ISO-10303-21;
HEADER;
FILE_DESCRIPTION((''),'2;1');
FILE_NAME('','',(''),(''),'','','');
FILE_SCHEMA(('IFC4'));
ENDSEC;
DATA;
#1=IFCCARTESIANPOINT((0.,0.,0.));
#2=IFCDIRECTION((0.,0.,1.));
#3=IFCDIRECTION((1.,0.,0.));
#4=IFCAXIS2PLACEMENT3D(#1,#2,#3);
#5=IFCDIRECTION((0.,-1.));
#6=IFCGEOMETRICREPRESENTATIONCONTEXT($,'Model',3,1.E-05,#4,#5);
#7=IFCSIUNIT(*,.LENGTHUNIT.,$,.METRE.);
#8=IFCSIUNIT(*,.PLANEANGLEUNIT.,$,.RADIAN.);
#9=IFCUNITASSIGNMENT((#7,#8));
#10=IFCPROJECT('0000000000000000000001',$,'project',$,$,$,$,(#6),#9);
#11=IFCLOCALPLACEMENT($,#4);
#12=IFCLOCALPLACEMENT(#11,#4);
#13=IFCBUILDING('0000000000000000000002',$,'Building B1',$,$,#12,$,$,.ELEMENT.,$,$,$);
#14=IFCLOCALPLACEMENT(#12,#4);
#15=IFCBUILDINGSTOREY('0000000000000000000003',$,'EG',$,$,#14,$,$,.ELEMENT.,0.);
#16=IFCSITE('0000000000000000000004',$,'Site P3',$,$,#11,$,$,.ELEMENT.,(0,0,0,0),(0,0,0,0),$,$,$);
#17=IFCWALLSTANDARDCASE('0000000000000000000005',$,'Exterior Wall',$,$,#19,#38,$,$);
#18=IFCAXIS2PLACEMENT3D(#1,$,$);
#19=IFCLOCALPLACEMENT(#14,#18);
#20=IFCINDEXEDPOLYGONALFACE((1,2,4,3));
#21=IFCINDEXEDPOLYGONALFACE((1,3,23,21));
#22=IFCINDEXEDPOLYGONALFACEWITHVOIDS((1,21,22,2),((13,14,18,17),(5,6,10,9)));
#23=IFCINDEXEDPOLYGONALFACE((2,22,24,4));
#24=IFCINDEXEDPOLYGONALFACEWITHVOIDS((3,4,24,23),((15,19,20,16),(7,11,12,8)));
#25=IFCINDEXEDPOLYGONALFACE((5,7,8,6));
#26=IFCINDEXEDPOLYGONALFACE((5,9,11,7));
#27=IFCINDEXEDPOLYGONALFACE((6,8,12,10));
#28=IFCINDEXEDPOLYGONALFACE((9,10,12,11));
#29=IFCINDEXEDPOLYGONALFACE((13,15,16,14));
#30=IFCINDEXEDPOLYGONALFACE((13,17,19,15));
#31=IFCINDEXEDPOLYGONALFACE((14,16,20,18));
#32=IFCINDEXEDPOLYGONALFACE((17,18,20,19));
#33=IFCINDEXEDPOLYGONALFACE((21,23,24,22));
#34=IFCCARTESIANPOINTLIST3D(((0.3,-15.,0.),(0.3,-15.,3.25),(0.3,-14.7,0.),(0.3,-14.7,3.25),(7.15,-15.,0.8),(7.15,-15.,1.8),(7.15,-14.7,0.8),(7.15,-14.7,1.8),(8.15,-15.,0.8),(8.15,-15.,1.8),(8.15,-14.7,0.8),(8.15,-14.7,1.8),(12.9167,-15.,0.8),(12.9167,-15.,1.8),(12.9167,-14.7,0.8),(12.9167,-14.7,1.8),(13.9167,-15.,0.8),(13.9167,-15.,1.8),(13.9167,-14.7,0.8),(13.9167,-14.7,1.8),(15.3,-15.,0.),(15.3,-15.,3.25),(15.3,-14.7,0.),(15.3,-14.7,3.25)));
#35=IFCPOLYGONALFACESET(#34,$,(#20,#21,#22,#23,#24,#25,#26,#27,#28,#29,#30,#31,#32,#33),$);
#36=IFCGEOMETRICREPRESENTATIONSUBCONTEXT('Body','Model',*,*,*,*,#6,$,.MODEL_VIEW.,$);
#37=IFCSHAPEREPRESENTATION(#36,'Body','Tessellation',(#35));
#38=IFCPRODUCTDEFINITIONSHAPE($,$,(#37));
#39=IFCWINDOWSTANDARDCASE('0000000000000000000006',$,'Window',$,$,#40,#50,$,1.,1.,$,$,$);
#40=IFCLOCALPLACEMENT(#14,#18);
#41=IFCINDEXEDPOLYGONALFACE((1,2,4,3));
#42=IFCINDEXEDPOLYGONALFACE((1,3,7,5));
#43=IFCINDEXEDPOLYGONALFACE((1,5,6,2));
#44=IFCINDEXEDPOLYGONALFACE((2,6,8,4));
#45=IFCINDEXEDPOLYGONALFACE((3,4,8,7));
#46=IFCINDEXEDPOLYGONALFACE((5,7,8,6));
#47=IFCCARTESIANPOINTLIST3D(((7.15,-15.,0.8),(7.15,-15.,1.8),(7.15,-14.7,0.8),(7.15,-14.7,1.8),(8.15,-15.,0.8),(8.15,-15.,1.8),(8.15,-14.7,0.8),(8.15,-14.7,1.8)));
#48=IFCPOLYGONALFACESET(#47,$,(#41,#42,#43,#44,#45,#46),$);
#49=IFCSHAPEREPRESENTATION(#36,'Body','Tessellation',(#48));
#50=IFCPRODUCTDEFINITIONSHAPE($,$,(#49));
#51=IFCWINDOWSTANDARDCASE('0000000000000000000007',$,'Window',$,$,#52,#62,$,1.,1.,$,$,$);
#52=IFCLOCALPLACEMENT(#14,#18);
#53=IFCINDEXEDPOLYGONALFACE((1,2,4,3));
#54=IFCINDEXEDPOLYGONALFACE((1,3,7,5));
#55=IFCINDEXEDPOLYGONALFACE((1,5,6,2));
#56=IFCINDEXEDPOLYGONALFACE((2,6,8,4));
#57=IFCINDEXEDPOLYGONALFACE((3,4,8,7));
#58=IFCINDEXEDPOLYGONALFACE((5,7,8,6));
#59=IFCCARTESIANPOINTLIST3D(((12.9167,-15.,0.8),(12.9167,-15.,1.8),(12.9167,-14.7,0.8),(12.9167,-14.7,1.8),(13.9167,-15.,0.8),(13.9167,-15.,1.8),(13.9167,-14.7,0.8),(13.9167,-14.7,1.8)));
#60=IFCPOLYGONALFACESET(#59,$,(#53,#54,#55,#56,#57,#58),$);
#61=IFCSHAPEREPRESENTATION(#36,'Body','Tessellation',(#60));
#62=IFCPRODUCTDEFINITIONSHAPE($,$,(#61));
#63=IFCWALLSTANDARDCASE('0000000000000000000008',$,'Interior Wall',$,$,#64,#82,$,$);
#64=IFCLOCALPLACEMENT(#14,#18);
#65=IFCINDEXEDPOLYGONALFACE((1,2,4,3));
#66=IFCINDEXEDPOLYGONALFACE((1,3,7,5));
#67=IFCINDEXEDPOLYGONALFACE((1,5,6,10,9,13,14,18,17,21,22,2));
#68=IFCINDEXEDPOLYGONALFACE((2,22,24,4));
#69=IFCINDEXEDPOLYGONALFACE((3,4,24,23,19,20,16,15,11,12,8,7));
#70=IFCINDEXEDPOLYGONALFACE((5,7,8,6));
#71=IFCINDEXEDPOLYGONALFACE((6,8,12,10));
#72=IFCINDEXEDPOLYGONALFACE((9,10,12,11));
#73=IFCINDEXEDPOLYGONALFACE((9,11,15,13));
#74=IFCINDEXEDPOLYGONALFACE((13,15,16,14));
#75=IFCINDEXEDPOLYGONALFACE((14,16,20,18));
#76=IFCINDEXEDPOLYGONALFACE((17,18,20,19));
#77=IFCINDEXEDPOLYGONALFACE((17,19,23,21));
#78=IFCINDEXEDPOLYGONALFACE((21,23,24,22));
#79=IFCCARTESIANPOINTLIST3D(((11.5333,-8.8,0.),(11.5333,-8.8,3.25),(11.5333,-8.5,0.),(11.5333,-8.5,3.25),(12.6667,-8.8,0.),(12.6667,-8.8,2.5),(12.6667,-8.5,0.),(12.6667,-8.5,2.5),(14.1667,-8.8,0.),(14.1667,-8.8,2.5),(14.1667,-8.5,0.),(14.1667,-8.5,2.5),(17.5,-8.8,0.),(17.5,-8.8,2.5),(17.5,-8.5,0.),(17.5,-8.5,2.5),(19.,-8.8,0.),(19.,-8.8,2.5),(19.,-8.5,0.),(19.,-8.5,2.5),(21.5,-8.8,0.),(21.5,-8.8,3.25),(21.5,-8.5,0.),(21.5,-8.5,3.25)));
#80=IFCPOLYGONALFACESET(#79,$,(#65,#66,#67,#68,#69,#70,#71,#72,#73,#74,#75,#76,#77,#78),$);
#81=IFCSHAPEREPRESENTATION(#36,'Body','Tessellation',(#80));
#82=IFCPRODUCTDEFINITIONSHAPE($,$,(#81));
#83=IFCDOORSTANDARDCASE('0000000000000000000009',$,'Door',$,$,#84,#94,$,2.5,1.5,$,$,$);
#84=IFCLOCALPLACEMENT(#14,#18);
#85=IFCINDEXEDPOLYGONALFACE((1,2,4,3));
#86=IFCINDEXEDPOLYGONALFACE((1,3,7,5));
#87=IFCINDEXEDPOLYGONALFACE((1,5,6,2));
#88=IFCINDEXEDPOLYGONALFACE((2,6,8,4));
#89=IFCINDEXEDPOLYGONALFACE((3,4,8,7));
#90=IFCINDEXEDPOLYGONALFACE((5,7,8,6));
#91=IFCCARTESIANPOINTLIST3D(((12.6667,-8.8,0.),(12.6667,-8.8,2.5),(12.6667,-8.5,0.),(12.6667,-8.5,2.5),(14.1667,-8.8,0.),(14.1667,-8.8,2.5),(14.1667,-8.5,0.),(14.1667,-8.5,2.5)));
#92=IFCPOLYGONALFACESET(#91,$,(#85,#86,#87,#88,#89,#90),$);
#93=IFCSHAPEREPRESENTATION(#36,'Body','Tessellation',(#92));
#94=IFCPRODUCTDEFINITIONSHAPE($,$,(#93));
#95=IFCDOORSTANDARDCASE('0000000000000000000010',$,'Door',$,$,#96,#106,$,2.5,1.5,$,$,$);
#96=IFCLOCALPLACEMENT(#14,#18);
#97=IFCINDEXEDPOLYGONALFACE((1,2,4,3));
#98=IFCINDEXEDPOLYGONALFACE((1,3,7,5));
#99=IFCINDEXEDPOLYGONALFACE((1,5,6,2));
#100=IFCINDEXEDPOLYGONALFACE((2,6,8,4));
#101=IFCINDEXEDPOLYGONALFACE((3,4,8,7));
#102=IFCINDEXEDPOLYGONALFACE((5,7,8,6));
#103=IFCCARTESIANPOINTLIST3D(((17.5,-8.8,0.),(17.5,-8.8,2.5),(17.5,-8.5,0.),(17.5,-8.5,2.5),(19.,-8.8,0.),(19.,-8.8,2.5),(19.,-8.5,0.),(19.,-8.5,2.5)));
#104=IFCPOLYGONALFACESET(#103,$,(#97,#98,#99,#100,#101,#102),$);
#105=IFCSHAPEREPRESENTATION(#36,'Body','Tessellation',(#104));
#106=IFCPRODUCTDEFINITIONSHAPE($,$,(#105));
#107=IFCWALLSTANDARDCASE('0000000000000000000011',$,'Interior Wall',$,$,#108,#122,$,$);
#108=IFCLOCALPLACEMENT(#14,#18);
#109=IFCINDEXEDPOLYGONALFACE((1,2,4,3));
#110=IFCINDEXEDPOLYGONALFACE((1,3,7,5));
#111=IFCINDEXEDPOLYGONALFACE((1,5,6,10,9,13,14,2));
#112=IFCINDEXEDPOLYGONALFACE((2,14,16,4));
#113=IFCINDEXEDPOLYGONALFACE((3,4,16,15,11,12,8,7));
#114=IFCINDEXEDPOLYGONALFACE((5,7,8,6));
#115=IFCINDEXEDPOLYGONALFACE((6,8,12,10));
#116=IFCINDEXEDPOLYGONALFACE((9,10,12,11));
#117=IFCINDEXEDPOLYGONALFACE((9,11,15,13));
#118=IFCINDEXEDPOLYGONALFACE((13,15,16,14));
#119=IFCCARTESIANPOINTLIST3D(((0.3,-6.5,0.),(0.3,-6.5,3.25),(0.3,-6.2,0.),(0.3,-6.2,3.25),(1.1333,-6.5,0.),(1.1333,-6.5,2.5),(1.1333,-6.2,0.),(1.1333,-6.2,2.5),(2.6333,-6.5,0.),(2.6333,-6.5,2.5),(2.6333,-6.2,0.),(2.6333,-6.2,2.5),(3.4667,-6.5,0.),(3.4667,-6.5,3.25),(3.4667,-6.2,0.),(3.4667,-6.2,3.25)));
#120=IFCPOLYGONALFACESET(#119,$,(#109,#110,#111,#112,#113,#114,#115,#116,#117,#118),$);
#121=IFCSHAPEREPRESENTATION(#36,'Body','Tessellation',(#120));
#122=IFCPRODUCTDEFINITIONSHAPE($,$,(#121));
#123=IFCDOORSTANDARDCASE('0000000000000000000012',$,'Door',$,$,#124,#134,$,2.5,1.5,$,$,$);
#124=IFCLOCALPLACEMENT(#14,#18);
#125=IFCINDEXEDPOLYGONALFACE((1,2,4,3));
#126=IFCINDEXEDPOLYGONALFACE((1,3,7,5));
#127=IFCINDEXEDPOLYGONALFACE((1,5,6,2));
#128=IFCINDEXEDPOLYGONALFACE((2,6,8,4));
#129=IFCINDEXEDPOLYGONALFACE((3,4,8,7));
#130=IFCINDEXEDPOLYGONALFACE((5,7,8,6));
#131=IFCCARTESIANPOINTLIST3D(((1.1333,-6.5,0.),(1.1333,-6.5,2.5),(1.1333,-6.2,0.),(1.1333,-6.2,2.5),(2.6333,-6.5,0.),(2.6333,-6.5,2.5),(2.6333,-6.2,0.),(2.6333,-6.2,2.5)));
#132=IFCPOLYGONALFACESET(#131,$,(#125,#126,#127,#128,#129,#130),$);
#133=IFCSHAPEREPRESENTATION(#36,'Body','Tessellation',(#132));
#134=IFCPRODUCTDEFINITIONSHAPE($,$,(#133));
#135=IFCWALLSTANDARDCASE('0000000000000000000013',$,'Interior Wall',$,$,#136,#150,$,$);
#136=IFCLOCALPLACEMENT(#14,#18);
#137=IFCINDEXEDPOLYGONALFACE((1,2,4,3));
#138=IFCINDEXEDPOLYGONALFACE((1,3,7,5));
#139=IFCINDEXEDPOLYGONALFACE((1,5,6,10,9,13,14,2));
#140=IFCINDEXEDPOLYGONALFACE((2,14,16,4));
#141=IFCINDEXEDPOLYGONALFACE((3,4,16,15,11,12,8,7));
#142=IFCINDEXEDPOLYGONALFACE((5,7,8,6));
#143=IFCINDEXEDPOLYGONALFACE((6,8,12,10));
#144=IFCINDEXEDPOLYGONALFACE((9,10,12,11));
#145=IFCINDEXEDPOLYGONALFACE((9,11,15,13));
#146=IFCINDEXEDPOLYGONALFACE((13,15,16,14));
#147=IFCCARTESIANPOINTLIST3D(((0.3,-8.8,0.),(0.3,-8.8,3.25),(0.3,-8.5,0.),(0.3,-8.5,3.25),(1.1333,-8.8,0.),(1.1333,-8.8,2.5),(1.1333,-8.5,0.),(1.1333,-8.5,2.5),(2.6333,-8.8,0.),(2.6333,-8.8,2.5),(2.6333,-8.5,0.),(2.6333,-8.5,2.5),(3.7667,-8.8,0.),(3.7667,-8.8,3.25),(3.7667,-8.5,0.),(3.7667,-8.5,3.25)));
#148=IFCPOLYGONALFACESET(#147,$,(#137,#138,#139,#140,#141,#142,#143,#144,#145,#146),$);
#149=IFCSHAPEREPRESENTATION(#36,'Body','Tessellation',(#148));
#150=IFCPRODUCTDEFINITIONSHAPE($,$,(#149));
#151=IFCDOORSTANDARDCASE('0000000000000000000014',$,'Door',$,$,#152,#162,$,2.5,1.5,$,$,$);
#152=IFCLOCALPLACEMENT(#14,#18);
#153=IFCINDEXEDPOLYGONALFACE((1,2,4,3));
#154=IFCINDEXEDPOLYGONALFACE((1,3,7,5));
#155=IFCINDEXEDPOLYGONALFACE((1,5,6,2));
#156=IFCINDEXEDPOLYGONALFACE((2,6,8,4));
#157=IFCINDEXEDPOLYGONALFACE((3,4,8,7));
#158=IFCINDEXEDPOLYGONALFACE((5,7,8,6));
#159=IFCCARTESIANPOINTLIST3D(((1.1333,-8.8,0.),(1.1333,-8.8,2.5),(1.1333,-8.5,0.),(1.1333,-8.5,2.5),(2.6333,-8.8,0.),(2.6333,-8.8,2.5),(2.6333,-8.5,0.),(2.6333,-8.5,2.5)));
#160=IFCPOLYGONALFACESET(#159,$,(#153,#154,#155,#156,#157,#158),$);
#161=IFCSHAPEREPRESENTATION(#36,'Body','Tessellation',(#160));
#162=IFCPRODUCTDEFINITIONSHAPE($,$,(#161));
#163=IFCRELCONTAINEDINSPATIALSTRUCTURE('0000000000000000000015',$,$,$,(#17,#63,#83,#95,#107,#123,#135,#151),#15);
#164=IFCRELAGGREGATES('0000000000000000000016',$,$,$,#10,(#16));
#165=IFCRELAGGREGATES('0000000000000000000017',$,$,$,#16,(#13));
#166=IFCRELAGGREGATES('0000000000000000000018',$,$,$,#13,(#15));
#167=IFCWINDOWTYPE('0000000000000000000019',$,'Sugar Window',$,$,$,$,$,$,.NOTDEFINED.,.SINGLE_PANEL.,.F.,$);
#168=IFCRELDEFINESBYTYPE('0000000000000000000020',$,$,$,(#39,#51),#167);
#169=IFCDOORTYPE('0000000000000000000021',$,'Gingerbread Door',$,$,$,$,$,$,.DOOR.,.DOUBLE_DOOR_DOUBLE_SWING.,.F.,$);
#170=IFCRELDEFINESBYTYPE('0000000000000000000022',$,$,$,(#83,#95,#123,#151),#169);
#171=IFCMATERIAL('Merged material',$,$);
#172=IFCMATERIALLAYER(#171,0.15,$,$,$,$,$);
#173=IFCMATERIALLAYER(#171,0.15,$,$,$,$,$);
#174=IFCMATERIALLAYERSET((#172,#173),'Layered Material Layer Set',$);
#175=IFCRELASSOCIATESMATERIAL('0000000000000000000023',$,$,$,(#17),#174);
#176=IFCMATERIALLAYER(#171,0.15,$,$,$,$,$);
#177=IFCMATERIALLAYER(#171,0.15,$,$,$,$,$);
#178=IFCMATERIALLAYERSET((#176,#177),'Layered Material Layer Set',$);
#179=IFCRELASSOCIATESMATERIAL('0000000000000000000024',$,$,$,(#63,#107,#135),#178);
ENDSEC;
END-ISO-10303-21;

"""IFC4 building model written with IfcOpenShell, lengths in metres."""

from ifc_helpers import new_model, si_unit, direction, frame, origin_with_axes, place, context, subcontext, project, spatial, polyline, outline, extrude, source, transform, mapped, material, layer, layer_set, layer_usage, type_object, element, fill, save


model = new_model("IFC4")

# Units and contexts
model_context = context("Model", 3, precision=1e-05, world=origin_with_axes(), true_north=direction((0.0, -1.0)))
body_context = subcontext(model_context, "Body", "Model", "MODEL_VIEW")
ifc_project = project(units=[si_unit("LENGTHUNIT", "METRE"), si_unit("PLANEANGLEUNIT", "RADIAN")], contexts=[model_context])

# Site, building, storey
site_placement = place(None, origin_with_axes())
site = spatial("IfcSite", under=ifc_project, at=site_placement, Name="Site P3", CompositionType="ELEMENT", RefLatitude=(0, 0, 0, 0), RefLongitude=(0, 0, 0, 0))
building_placement = place(site_placement, origin_with_axes())
building = spatial("IfcBuilding", under=site, at=building_placement, Name="Building B1", CompositionType="ELEMENT")
storey_placement = place(building_placement, origin_with_axes())
storey = spatial("IfcBuildingStorey", under=building, at=storey_placement, Name="EG", CompositionType="ELEMENT", Elevation=0.0)

# Wall, openings, windows
ifc_material = material(Name="Merged material")
ifc_layer_1 = layer(ifc_material, 0.15)
ifc_layer_2 = layer(ifc_material, 0.15)
ifc_layer_set_1 = layer_set([ifc_layer_1, ifc_layer_2], Name="Layered Material Layer Set")
ifc_layer_usage_1 = layer_usage(ifc_layer_set_1, "AXIS2", "POSITIVE", -0.15)
wall_1_placement = place(storey_placement, frame((0.3, -14.85, 0.0), z_axis=(0.0, 0.0, 1.0), x_axis=(1.0, 0.0, 0.0)))
wall_1 = element("IfcWallStandardCase", 1, at=wall_1_placement, inside=storey, material=ifc_layer_usage_1, Name="Exterior Wall", context=body_context, shape_type="SweptSolid", body=[
    extrude(outline(polyline([(0.0, 0.15), (15.0, 0.15), (15.0, -0.15), (0.0, -0.15), (0.0, 0.15)])), origin_with_axes(), (0.0, 0.0, 1.0), 3.25),
])
opening_1_placement = place(wall_1_placement, frame((6.85, 0.0, 0.8), z_axis=(0.0, 0.0, 1.0), x_axis=(1.0, 0.0, 0.0)))
opening_1 = element("IfcOpeningStandardCase", 2, at=opening_1_placement, cuts=wall_1, context=body_context, shape_type="SweptSolid", body=[
    extrude(outline(polyline([(0.0, 0.0), (0.0, 1.0), (1.0, 1.0), (1.0, 0.0), (0.0, 0.0)])), frame((0.0, -0.15, 0.0), z_axis=(0.0, 1.0, 0.0), x_axis=(0.0, 0.0, 1.0)), (0.0, 0.0, 1.0), 0.3),
])
opening_2_placement = place(wall_1_placement, frame((12.6167, 0.0, 0.8), z_axis=(0.0, 0.0, 1.0), x_axis=(1.0, 0.0, 0.0)))
opening_2 = element("IfcOpeningStandardCase", 3, at=opening_2_placement, cuts=wall_1, context=body_context, shape_type="SweptSolid", body=[
    extrude(outline(polyline([(0.0, 0.0), (0.0, 1.0), (1.0, 1.0), (1.0, 0.0), (0.0, 0.0)])), frame((0.0, -0.15, 0.0), z_axis=(0.0, 1.0, 0.0), x_axis=(0.0, 0.0, 1.0)), (0.0, 0.0, 1.0), 0.3),
])
window_type = type_object("IfcWindowType", Name="Sugar Window", ParameterTakesPrecedence=False, PartitioningType="SINGLE_PANEL", PredefinedType="NOTDEFINED")
shared_shape_1 = source(origin_with_axes(), body_context, "Body", "SweptSolid", [
    extrude(outline(polyline([(0.0, 0.0), (0.0, 1.0), (1.0, 1.0), (1.0, 0.0), (0.0, 0.0)])), frame((0.0, -0.15, 0.0), z_axis=(0.0, 1.0, 0.0), x_axis=(0.0, 0.0, 1.0)), (0.0, 0.0, 1.0), 0.3),
])
window_1_placement = place(opening_1_placement, origin_with_axes())
window_1 = element("IfcWindowStandardCase", 4, at=window_1_placement, type_object=window_type, Name="Window", OverallHeight=1.0, OverallWidth=1.0, context=body_context, shape_type="MappedRepresentation", body=[
    mapped(shared_shape_1, transform((0.0, 0.0, 0.0))),
])
fill(opening_1, window_1)
window_2_placement = place(opening_2_placement, origin_with_axes())
window_2 = element("IfcWindowStandardCase", 5, at=window_2_placement, type_object=window_type, Name="Window", OverallHeight=1.0, OverallWidth=1.0, context=body_context, shape_type="MappedRepresentation", body=[
    mapped(shared_shape_1, transform((0.0, 0.0, 0.0))),
])
fill(opening_2, window_2)

# Wall, openings, doors
ifc_layer_3 = layer(ifc_material, 0.15)
ifc_layer_4 = layer(ifc_material, 0.15)
ifc_layer_set_2 = layer_set([ifc_layer_3, ifc_layer_4], Name="Layered Material Layer Set")
ifc_layer_usage_2 = layer_usage(ifc_layer_set_2, "AXIS2", "POSITIVE", -0.15)
wall_2_placement = place(storey_placement, frame((11.5333, -8.65, 0.0), z_axis=(0.0, 0.0, 1.0), x_axis=(1.0, 0.0, 0.0)))
wall_2 = element("IfcWallStandardCase", 6, at=wall_2_placement, inside=storey, material=ifc_layer_usage_2, Name="Interior Wall", context=body_context, shape_type="SweptSolid", body=[
    extrude(outline(polyline([(0.0, 0.15), (9.9667, 0.15), (9.9667, -0.15), (0.0, -0.15), (0.0, 0.15)])), origin_with_axes(), (0.0, 0.0, 1.0), 3.25),
])
opening_3_placement = place(wall_2_placement, frame((1.1333, 0.0, 0.0), z_axis=(0.0, 0.0, 1.0), x_axis=(1.0, 0.0, 0.0)))
opening_3 = element("IfcOpeningStandardCase", 7, at=opening_3_placement, cuts=wall_2, context=body_context, shape_type="SweptSolid", body=[
    extrude(outline(polyline([(0.0, 0.0), (0.0, 1.5), (2.5, 1.5), (2.5, 0.0), (0.0, 0.0)])), frame((0.0, -0.15, 0.0), z_axis=(0.0, 1.0, 0.0), x_axis=(0.0, 0.0, 1.0)), (0.0, 0.0, 1.0), 0.3),
])
opening_4_placement = place(wall_2_placement, frame((5.9667, 0.0, 0.0), z_axis=(0.0, 0.0, 1.0), x_axis=(1.0, 0.0, 0.0)))
opening_4 = element("IfcOpeningStandardCase", 8, at=opening_4_placement, cuts=wall_2, context=body_context, shape_type="SweptSolid", body=[
    extrude(outline(polyline([(0.0, 0.0), (0.0, 1.5), (2.5, 1.5), (2.5, 0.0), (0.0, 0.0)])), frame((0.0, -0.15, 0.0), z_axis=(0.0, 1.0, 0.0), x_axis=(0.0, 0.0, 1.0)), (0.0, 0.0, 1.0), 0.3),
])
door_type = type_object("IfcDoorType", Name="Gingerbread Door", OperationType="DOUBLE_DOOR_DOUBLE_SWING", ParameterTakesPrecedence=False, PredefinedType="DOOR")
shared_shape_2 = source(origin_with_axes(), body_context, "Body", "SweptSolid", [
    extrude(outline(polyline([(0.0, 0.0), (0.0, 1.5), (2.5, 1.5), (2.5, 0.0), (0.0, 0.0)])), frame((0.0, -0.15, 0.0), z_axis=(0.0, 1.0, 0.0), x_axis=(0.0, 0.0, 1.0)), (0.0, 0.0, 1.0), 0.3),
])
door_1_placement = place(opening_3_placement, origin_with_axes())
door_1 = element("IfcDoorStandardCase", 9, at=door_1_placement, inside=storey, type_object=door_type, Name="Door", OverallHeight=2.5, OverallWidth=1.5, context=body_context, shape_type="MappedRepresentation", body=[
    mapped(shared_shape_2, transform((0.0, 0.0, 0.0))),
])
fill(opening_3, door_1)
door_2_placement = place(opening_4_placement, origin_with_axes())
door_2 = element("IfcDoorStandardCase", 10, at=door_2_placement, inside=storey, type_object=door_type, Name="Door", OverallHeight=2.5, OverallWidth=1.5, context=body_context, shape_type="MappedRepresentation", body=[
    mapped(shared_shape_2, transform((0.0, 0.0, 0.0))),
])
fill(opening_4, door_2)

# Walls, openings, doors
wall_3_placement = place(storey_placement, frame((0.3, -6.35, 0.0), z_axis=(0.0, 0.0, 1.0), x_axis=(1.0, 0.0, 0.0)))
wall_3 = element("IfcWallStandardCase", 11, at=wall_3_placement, inside=storey, material=ifc_layer_usage_2, Name="Interior Wall", context=body_context, shape_type="SweptSolid", body=[
    extrude(outline(polyline([(0.0, 0.15), (3.1667, 0.15), (3.1667, -0.15), (0.0, -0.15), (0.0, 0.15)])), origin_with_axes(), (0.0, 0.0, 1.0), 3.25),
])
opening_5_placement = place(wall_3_placement, frame((0.8333, 0.0, 0.0), z_axis=(0.0, 0.0, 1.0), x_axis=(1.0, 0.0, 0.0)))
opening_5 = element("IfcOpeningStandardCase", 12, at=opening_5_placement, cuts=wall_3, context=body_context, shape_type="SweptSolid", body=[
    extrude(outline(polyline([(0.0, 0.0), (0.0, 1.5), (2.5, 1.5), (2.5, 0.0), (0.0, 0.0)])), frame((0.0, -0.15, 0.0), z_axis=(0.0, 1.0, 0.0), x_axis=(0.0, 0.0, 1.0)), (0.0, 0.0, 1.0), 0.3),
])
door_3_placement = place(opening_5_placement, origin_with_axes())
door_3 = element("IfcDoorStandardCase", 13, at=door_3_placement, inside=storey, type_object=door_type, Name="Door", OverallHeight=2.5, OverallWidth=1.5, context=body_context, shape_type="MappedRepresentation", body=[
    mapped(shared_shape_2, transform((0.0, 0.0, 0.0))),
])
fill(opening_5, door_3)
wall_4_placement = place(storey_placement, frame((0.3, -8.65, 0.0), z_axis=(0.0, 0.0, 1.0), x_axis=(1.0, 0.0, 0.0)))
wall_4 = element("IfcWallStandardCase", 14, at=wall_4_placement, inside=storey, material=ifc_layer_usage_2, Name="Interior Wall", context=body_context, shape_type="SweptSolid", body=[
    extrude(outline(polyline([(0.0, 0.15), (3.4667, 0.15), (3.4667, -0.15), (0.0, -0.15), (0.0, 0.15)])), origin_with_axes(), (0.0, 0.0, 1.0), 3.25),
])
opening_6_placement = place(wall_4_placement, frame((0.8333, 0.0, 0.0), z_axis=(0.0, 0.0, 1.0), x_axis=(1.0, 0.0, 0.0)))
opening_6 = element("IfcOpeningStandardCase", 15, at=opening_6_placement, cuts=wall_4, context=body_context, shape_type="SweptSolid", body=[
    extrude(outline(polyline([(0.0, 0.0), (0.0, 1.5), (2.5, 1.5), (2.5, 0.0), (0.0, 0.0)])), frame((0.0, -0.15, 0.0), z_axis=(0.0, 1.0, 0.0), x_axis=(0.0, 0.0, 1.0)), (0.0, 0.0, 1.0), 0.3),
])
door_4_placement = place(opening_6_placement, origin_with_axes())
door_4 = element("IfcDoorStandardCase", 16, at=door_4_placement, inside=storey, type_object=door_type, Name="Door", OverallHeight=2.5, OverallWidth=1.5, context=body_context, shape_type="MappedRepresentation", body=[
    mapped(shared_shape_2, transform((0.0, 0.0, 0.0))),
])
fill(opening_6, door_4)

save(model, "model.ifc")
